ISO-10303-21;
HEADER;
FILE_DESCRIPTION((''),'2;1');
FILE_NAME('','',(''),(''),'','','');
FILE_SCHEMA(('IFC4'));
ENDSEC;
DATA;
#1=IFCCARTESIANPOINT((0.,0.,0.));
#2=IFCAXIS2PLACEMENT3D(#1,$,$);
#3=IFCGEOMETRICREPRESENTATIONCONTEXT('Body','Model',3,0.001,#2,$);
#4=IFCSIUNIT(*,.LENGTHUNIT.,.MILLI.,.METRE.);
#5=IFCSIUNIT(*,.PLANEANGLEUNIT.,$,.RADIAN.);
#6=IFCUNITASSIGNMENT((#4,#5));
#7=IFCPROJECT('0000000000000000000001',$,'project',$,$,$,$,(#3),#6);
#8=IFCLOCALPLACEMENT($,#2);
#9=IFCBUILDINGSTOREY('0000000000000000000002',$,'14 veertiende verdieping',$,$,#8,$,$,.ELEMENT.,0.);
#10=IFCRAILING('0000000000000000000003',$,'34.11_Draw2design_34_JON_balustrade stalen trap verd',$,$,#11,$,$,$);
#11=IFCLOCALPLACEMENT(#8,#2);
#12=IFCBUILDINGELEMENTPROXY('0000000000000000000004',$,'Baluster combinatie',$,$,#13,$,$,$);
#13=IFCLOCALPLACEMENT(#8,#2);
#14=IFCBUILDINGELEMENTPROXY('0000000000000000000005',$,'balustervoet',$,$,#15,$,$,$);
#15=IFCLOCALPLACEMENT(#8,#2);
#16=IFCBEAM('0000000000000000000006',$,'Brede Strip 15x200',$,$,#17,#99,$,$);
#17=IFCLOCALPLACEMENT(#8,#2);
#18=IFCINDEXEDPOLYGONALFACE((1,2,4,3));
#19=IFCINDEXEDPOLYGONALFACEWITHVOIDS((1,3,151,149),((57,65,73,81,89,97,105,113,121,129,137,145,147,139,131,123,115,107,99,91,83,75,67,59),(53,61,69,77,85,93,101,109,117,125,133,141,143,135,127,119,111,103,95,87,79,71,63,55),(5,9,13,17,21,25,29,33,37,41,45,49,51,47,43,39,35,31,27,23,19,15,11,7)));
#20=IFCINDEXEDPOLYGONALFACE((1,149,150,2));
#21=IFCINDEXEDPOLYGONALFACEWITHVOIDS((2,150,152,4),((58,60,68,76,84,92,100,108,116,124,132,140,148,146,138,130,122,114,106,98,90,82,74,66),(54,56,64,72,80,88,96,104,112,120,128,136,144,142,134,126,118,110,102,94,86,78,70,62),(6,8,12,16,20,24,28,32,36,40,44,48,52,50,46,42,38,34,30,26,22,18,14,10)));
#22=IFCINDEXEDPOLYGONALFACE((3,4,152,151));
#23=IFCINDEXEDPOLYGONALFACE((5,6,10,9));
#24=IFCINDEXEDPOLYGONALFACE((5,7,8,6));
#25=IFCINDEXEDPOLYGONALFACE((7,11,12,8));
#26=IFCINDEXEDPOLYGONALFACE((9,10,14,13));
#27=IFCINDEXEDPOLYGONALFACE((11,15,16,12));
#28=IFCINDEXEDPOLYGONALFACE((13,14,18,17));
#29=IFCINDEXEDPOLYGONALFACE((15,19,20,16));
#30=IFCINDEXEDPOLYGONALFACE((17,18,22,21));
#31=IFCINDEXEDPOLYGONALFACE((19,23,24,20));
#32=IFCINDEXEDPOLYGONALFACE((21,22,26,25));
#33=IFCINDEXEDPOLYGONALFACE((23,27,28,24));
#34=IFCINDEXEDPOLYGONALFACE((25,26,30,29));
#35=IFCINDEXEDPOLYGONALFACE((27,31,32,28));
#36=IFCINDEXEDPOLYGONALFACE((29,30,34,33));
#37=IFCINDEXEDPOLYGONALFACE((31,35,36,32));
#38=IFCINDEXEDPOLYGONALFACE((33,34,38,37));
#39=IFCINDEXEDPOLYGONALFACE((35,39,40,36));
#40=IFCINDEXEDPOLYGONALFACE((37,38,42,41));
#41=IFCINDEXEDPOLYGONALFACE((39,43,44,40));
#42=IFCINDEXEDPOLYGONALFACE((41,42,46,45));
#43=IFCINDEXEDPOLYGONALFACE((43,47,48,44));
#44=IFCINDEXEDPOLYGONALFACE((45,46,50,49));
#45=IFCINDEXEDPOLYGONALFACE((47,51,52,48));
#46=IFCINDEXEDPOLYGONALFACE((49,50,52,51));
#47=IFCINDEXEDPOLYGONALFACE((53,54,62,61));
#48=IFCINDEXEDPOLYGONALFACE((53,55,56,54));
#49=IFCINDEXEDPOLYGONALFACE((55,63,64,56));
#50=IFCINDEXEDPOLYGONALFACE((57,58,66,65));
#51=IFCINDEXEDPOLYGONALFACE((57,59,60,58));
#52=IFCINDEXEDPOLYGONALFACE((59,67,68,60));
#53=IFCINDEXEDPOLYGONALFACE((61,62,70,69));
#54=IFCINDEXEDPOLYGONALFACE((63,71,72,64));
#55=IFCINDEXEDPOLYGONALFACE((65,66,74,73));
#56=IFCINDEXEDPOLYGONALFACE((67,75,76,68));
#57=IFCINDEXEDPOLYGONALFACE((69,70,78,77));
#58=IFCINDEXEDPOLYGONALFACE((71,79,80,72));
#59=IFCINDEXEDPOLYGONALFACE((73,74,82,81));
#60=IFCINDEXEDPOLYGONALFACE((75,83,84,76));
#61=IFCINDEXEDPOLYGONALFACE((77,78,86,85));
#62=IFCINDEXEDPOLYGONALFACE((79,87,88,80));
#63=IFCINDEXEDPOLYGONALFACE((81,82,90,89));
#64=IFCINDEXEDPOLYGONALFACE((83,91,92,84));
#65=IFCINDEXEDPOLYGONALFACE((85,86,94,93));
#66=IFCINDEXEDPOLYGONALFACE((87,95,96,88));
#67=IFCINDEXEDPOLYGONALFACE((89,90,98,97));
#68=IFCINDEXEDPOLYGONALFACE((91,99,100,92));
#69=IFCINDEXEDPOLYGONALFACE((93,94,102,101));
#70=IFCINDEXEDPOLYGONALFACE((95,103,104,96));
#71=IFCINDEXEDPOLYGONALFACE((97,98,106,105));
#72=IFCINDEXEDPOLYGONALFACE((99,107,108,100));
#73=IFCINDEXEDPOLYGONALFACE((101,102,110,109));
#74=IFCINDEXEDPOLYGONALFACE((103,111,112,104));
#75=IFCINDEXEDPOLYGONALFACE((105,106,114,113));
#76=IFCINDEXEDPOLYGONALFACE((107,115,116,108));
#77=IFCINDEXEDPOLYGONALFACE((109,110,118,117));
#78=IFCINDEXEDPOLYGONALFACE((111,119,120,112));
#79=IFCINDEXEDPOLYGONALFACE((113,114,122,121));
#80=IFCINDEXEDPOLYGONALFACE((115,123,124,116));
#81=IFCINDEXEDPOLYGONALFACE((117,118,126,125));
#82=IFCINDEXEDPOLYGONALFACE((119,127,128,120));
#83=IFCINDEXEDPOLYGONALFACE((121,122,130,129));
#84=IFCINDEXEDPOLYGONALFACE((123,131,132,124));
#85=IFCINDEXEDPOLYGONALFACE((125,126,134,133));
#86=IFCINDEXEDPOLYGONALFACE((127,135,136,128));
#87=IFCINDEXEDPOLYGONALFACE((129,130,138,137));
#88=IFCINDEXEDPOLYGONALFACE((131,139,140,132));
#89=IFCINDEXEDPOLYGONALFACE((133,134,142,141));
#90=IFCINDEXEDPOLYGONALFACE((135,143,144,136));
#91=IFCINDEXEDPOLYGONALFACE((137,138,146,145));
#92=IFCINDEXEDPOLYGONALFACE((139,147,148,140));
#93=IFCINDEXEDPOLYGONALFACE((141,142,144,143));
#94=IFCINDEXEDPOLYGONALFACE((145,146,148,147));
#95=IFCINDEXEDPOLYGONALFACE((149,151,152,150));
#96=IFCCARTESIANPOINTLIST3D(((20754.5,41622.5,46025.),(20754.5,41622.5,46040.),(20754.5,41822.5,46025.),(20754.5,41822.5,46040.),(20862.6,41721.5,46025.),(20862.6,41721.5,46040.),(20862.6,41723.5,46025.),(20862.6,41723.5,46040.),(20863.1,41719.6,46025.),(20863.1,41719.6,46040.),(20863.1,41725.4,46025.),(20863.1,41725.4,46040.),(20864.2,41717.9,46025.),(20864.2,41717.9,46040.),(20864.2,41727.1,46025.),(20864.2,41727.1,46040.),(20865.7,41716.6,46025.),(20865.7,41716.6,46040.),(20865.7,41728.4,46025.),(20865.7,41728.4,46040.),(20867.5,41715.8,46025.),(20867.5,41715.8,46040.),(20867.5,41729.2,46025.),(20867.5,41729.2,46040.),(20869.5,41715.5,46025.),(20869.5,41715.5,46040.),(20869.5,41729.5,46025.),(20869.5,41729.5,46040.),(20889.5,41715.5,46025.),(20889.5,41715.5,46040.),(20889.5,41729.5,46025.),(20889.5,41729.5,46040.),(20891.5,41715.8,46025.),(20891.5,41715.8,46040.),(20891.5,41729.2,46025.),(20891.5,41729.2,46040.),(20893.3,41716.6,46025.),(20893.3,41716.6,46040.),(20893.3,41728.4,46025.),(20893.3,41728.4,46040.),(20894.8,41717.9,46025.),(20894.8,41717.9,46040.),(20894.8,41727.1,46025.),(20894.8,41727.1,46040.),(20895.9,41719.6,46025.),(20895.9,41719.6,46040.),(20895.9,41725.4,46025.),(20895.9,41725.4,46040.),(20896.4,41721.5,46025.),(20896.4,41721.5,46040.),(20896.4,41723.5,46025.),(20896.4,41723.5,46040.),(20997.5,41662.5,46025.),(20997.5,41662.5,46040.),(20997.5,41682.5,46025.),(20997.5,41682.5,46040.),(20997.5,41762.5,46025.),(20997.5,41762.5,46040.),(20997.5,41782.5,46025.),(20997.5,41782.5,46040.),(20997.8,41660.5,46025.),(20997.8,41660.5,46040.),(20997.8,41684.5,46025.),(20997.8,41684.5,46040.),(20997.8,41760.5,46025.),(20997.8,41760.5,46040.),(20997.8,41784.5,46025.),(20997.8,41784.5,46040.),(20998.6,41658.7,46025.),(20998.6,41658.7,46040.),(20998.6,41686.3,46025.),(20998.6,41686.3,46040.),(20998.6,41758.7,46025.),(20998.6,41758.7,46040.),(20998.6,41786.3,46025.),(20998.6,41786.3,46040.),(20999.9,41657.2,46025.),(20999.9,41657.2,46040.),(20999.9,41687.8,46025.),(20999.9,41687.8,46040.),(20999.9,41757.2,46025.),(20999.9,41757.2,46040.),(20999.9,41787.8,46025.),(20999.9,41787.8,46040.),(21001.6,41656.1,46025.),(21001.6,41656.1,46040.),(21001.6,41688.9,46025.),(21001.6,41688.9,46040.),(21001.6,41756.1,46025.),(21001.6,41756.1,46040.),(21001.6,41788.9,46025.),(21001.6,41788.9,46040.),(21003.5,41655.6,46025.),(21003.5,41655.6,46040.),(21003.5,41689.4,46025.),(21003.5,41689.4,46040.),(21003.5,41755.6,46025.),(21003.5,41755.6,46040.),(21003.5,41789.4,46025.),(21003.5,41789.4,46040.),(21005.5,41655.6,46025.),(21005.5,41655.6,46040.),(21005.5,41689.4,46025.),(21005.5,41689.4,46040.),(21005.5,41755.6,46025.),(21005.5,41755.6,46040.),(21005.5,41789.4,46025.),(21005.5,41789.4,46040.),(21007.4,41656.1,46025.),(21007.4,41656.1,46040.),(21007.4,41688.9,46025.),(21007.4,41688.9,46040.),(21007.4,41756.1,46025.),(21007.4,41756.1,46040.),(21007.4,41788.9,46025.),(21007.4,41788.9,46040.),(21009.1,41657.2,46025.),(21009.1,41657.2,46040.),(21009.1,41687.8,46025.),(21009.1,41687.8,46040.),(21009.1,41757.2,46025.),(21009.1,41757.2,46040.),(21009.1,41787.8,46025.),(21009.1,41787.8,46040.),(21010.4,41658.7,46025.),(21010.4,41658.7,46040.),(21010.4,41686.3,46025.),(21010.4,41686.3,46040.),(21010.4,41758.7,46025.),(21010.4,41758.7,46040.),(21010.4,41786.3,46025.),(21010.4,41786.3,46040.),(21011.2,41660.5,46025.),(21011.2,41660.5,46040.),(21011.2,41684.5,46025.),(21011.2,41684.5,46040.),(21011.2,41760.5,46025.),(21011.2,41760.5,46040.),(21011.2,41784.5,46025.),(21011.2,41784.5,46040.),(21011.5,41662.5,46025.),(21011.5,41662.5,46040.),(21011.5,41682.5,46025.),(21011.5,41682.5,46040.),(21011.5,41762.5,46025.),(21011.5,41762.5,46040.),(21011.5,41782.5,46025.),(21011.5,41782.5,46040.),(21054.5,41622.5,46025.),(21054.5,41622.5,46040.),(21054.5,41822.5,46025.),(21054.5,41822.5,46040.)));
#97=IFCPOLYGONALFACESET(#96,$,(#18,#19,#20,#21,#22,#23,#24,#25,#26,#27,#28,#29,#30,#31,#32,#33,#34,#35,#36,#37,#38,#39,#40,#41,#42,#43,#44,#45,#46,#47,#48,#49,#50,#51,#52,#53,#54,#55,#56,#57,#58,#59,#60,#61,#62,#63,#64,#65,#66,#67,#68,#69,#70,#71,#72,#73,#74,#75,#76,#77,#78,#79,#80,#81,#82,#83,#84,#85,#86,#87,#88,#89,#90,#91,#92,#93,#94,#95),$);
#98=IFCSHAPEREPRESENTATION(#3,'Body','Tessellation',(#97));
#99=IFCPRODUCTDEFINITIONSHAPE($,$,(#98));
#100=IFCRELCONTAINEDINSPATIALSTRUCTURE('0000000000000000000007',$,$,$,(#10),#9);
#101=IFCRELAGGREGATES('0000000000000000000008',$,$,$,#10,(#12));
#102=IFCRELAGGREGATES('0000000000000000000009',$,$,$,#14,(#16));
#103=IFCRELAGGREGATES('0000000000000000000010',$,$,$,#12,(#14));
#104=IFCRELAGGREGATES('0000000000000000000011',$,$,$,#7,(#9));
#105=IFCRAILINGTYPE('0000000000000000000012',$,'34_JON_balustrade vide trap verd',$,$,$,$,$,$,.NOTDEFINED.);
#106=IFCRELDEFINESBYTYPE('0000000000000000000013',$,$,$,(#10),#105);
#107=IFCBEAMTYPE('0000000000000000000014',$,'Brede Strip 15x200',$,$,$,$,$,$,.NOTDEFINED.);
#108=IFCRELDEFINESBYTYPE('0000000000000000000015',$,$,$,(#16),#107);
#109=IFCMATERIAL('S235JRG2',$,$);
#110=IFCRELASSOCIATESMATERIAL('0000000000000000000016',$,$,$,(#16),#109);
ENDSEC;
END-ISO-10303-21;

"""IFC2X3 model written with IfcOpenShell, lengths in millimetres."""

from ifc_helpers import new_model, si_unit, point, frame, frame_2d, origin, origin_2d, place, context, project, spatial, circle_curve, line_curve, trimmed, segment, composite_curve, rectangle, outline, extrude, source, transform, mapped, material, type_object, element, aggregate, save


model = new_model("IFC2X3")

# Units and contexts
model_context = context("Model", 3, precision=0.001, world=origin(), identifier="Body")
ifc_project = project(units=[si_unit("LENGTHUNIT", "METRE", prefix="MILLI"), si_unit("PLANEANGLEUNIT", "RADIAN")], contexts=[model_context])

# Storey
storey_placement = place(None, origin())
storey = spatial("IfcBuildingStorey", under=ifc_project, at=storey_placement, Name="14 veertiende verdieping", CompositionType="ELEMENT", Elevation=0.0)

# Railing, building element proxies, beam, openings
railing_type = type_object("IfcRailingType", Name="34_JON_balustrade vide trap verd")
railing_placement = place(storey_placement, frame((-1939.6, -577.1, 100383.6)))
railing = element("IfcRailing", 1, at=railing_placement, inside=storey, type_object=railing_type, Name="34.11_Draw2design_34_JON_balustrade stalen trap verd")
proxy_1_placement = place(railing_placement, frame((24081.1, 45997.7, -55496.7), z_axis=(0.0, 0.0, 1.0), x_axis=(0.0, 1.0, 0.0)))
proxy_1 = element("IfcBuildingElementProxy", 2, at=proxy_1_placement, Name="Baluster combinatie")
aggregate(railing, [proxy_1])
ifc_material_1 = material(Name="S235JRG2")
proxy_2_placement = place(proxy_1_placement, frame((-48610.6, 22141.4, -48086.9), z_axis=(0.0, 0.0, 1.0), x_axis=(0.0, -1.0, 0.0)))
proxy_2 = element("IfcBuildingElementProxy", 3, at=proxy_2_placement, Name="balustervoet")
beam_type_1 = type_object("IfcBeamType", Name="Brede Strip 15x200")
shared_shape_1 = source(origin(), model_context, "Body", "SweptSolid", [
    extrude(rectangle(XDim=15.0, YDim=200.0, at=origin_2d()), origin(), (0.0, 0.0, -1.0), 300.0),
])
beam_1_placement = place(proxy_2_placement, frame((21054.5, 44912.5, 49232.5), z_axis=(1.0, 0.0, 0.0), x_axis=(0.0, 0.0, 1.0)))
beam_1 = element("IfcBeam", 4, at=beam_1_placement, type_object=beam_type_1, material=ifc_material_1, Name="Brede Strip 15x200", context=model_context, shape_type="MappedRepresentation", body=[
    mapped(shared_shape_1, transform((0.0, 0.0, 0.0), scale=1.0)),
])
opening_1_placement = place(beam_1_placement, frame((7.5, 0.0, -175.0), z_axis=(-1.0, 0.0, 0.0), x_axis=(0.0, 0.0, -1.0)))
element("IfcOpeningElement", 5, at=opening_1_placement, cuts=beam_1, ObjectType="Opening", context=model_context, shape_type="SweptSolid", body=[
    extrude(outline(composite_curve([segment(trimmed(circle_curve(frame_2d((10.0, 0.0), x_axis=(0.0, -1.0)), 7.0), [point((10.0, 7.0))], [point((10.0, -7.0))], False, "CARTESIAN"), True, "CONTINUOUS"), segment(trimmed(line_curve((10.0, -7.0), (-20.0, 0.0), 20.0), [point((10.0, -7.0))], [point((-10.0, -7.0))], True, "CARTESIAN"), True, "CONTINUOUS"), segment(trimmed(circle_curve(frame_2d((-10.0, 0.0), x_axis=(0.0, -1.0)), 7.0), [point((-10.0, -7.0))], [point((-10.0, 7.0))], False, "CARTESIAN"), True, "CONTINUOUS"), segment(trimmed(line_curve((-10.0, 7.0), (20.0, 0.0), 20.0), [point((-10.0, 7.0))], [point((10.0, 7.0))], True, "CARTESIAN"), True, "CONTINUOUS")], self_intersect=False)), origin(), (0.0, 0.0, 1.0), 15.0),
])
opening_2_placement = place(beam_1_placement, frame((7.5, -50.0, -50.0), z_axis=(-1.0, 0.0, 0.0), x_axis=(0.0, -1.0, 0.0)))
element("IfcOpeningElement", 6, at=opening_2_placement, cuts=beam_1, ObjectType="Opening", context=model_context, shape_type="SweptSolid", body=[
    extrude(outline(composite_curve([segment(trimmed(circle_curve(frame_2d((10.0, 0.0), x_axis=(0.0, -1.0)), 7.0), [point((10.0, 7.0))], [point((10.0, -7.0))], False, "CARTESIAN"), True, "CONTINUOUS"), segment(trimmed(line_curve((10.0, -7.0), (-20.0, 0.0), 20.0), [point((10.0, -7.0))], [point((-10.0, -7.0))], True, "CARTESIAN"), True, "CONTINUOUS"), segment(trimmed(circle_curve(frame_2d((-10.0, 0.0), x_axis=(0.0, -1.0)), 7.0), [point((-10.0, -7.0))], [point((-10.0, 7.0))], False, "CARTESIAN"), True, "CONTINUOUS"), segment(trimmed(line_curve((-10.0, 7.0), (20.0, 0.0), 20.0), [point((-10.0, 7.0))], [point((10.0, 7.0))], True, "CARTESIAN"), True, "CONTINUOUS")], self_intersect=False)), origin(), (0.0, 0.0, 1.0), 15.0),
])
opening_3_placement = place(beam_1_placement, frame((7.5, 50.0, -50.0), z_axis=(-1.0, 0.0, 0.0), x_axis=(0.0, -1.0, 0.0)))
element("IfcOpeningElement", 7, at=opening_3_placement, cuts=beam_1, ObjectType="Opening", context=model_context, shape_type="SweptSolid", body=[
    extrude(outline(composite_curve([segment(trimmed(circle_curve(frame_2d((10.0, 0.0), x_axis=(0.0, -1.0)), 7.0), [point((10.0, 7.0))], [point((10.0, -7.0))], False, "CARTESIAN"), True, "CONTINUOUS"), segment(trimmed(line_curve((10.0, -7.0), (-20.0, 0.0), 20.0), [point((10.0, -7.0))], [point((-10.0, -7.0))], True, "CARTESIAN"), True, "CONTINUOUS"), segment(trimmed(circle_curve(frame_2d((-10.0, 0.0), x_axis=(0.0, -1.0)), 7.0), [point((-10.0, -7.0))], [point((-10.0, 7.0))], False, "CARTESIAN"), True, "CONTINUOUS"), segment(trimmed(line_curve((-10.0, 7.0), (20.0, 0.0), 20.0), [point((-10.0, 7.0))], [point((10.0, 7.0))], True, "CARTESIAN"), True, "CONTINUOUS")], self_intersect=False)), origin(), (0.0, 0.0, 1.0), 15.0),
])
aggregate(proxy_2, [beam_1])
aggregate(proxy_1, [proxy_2])

save(model, "model.ifc")
